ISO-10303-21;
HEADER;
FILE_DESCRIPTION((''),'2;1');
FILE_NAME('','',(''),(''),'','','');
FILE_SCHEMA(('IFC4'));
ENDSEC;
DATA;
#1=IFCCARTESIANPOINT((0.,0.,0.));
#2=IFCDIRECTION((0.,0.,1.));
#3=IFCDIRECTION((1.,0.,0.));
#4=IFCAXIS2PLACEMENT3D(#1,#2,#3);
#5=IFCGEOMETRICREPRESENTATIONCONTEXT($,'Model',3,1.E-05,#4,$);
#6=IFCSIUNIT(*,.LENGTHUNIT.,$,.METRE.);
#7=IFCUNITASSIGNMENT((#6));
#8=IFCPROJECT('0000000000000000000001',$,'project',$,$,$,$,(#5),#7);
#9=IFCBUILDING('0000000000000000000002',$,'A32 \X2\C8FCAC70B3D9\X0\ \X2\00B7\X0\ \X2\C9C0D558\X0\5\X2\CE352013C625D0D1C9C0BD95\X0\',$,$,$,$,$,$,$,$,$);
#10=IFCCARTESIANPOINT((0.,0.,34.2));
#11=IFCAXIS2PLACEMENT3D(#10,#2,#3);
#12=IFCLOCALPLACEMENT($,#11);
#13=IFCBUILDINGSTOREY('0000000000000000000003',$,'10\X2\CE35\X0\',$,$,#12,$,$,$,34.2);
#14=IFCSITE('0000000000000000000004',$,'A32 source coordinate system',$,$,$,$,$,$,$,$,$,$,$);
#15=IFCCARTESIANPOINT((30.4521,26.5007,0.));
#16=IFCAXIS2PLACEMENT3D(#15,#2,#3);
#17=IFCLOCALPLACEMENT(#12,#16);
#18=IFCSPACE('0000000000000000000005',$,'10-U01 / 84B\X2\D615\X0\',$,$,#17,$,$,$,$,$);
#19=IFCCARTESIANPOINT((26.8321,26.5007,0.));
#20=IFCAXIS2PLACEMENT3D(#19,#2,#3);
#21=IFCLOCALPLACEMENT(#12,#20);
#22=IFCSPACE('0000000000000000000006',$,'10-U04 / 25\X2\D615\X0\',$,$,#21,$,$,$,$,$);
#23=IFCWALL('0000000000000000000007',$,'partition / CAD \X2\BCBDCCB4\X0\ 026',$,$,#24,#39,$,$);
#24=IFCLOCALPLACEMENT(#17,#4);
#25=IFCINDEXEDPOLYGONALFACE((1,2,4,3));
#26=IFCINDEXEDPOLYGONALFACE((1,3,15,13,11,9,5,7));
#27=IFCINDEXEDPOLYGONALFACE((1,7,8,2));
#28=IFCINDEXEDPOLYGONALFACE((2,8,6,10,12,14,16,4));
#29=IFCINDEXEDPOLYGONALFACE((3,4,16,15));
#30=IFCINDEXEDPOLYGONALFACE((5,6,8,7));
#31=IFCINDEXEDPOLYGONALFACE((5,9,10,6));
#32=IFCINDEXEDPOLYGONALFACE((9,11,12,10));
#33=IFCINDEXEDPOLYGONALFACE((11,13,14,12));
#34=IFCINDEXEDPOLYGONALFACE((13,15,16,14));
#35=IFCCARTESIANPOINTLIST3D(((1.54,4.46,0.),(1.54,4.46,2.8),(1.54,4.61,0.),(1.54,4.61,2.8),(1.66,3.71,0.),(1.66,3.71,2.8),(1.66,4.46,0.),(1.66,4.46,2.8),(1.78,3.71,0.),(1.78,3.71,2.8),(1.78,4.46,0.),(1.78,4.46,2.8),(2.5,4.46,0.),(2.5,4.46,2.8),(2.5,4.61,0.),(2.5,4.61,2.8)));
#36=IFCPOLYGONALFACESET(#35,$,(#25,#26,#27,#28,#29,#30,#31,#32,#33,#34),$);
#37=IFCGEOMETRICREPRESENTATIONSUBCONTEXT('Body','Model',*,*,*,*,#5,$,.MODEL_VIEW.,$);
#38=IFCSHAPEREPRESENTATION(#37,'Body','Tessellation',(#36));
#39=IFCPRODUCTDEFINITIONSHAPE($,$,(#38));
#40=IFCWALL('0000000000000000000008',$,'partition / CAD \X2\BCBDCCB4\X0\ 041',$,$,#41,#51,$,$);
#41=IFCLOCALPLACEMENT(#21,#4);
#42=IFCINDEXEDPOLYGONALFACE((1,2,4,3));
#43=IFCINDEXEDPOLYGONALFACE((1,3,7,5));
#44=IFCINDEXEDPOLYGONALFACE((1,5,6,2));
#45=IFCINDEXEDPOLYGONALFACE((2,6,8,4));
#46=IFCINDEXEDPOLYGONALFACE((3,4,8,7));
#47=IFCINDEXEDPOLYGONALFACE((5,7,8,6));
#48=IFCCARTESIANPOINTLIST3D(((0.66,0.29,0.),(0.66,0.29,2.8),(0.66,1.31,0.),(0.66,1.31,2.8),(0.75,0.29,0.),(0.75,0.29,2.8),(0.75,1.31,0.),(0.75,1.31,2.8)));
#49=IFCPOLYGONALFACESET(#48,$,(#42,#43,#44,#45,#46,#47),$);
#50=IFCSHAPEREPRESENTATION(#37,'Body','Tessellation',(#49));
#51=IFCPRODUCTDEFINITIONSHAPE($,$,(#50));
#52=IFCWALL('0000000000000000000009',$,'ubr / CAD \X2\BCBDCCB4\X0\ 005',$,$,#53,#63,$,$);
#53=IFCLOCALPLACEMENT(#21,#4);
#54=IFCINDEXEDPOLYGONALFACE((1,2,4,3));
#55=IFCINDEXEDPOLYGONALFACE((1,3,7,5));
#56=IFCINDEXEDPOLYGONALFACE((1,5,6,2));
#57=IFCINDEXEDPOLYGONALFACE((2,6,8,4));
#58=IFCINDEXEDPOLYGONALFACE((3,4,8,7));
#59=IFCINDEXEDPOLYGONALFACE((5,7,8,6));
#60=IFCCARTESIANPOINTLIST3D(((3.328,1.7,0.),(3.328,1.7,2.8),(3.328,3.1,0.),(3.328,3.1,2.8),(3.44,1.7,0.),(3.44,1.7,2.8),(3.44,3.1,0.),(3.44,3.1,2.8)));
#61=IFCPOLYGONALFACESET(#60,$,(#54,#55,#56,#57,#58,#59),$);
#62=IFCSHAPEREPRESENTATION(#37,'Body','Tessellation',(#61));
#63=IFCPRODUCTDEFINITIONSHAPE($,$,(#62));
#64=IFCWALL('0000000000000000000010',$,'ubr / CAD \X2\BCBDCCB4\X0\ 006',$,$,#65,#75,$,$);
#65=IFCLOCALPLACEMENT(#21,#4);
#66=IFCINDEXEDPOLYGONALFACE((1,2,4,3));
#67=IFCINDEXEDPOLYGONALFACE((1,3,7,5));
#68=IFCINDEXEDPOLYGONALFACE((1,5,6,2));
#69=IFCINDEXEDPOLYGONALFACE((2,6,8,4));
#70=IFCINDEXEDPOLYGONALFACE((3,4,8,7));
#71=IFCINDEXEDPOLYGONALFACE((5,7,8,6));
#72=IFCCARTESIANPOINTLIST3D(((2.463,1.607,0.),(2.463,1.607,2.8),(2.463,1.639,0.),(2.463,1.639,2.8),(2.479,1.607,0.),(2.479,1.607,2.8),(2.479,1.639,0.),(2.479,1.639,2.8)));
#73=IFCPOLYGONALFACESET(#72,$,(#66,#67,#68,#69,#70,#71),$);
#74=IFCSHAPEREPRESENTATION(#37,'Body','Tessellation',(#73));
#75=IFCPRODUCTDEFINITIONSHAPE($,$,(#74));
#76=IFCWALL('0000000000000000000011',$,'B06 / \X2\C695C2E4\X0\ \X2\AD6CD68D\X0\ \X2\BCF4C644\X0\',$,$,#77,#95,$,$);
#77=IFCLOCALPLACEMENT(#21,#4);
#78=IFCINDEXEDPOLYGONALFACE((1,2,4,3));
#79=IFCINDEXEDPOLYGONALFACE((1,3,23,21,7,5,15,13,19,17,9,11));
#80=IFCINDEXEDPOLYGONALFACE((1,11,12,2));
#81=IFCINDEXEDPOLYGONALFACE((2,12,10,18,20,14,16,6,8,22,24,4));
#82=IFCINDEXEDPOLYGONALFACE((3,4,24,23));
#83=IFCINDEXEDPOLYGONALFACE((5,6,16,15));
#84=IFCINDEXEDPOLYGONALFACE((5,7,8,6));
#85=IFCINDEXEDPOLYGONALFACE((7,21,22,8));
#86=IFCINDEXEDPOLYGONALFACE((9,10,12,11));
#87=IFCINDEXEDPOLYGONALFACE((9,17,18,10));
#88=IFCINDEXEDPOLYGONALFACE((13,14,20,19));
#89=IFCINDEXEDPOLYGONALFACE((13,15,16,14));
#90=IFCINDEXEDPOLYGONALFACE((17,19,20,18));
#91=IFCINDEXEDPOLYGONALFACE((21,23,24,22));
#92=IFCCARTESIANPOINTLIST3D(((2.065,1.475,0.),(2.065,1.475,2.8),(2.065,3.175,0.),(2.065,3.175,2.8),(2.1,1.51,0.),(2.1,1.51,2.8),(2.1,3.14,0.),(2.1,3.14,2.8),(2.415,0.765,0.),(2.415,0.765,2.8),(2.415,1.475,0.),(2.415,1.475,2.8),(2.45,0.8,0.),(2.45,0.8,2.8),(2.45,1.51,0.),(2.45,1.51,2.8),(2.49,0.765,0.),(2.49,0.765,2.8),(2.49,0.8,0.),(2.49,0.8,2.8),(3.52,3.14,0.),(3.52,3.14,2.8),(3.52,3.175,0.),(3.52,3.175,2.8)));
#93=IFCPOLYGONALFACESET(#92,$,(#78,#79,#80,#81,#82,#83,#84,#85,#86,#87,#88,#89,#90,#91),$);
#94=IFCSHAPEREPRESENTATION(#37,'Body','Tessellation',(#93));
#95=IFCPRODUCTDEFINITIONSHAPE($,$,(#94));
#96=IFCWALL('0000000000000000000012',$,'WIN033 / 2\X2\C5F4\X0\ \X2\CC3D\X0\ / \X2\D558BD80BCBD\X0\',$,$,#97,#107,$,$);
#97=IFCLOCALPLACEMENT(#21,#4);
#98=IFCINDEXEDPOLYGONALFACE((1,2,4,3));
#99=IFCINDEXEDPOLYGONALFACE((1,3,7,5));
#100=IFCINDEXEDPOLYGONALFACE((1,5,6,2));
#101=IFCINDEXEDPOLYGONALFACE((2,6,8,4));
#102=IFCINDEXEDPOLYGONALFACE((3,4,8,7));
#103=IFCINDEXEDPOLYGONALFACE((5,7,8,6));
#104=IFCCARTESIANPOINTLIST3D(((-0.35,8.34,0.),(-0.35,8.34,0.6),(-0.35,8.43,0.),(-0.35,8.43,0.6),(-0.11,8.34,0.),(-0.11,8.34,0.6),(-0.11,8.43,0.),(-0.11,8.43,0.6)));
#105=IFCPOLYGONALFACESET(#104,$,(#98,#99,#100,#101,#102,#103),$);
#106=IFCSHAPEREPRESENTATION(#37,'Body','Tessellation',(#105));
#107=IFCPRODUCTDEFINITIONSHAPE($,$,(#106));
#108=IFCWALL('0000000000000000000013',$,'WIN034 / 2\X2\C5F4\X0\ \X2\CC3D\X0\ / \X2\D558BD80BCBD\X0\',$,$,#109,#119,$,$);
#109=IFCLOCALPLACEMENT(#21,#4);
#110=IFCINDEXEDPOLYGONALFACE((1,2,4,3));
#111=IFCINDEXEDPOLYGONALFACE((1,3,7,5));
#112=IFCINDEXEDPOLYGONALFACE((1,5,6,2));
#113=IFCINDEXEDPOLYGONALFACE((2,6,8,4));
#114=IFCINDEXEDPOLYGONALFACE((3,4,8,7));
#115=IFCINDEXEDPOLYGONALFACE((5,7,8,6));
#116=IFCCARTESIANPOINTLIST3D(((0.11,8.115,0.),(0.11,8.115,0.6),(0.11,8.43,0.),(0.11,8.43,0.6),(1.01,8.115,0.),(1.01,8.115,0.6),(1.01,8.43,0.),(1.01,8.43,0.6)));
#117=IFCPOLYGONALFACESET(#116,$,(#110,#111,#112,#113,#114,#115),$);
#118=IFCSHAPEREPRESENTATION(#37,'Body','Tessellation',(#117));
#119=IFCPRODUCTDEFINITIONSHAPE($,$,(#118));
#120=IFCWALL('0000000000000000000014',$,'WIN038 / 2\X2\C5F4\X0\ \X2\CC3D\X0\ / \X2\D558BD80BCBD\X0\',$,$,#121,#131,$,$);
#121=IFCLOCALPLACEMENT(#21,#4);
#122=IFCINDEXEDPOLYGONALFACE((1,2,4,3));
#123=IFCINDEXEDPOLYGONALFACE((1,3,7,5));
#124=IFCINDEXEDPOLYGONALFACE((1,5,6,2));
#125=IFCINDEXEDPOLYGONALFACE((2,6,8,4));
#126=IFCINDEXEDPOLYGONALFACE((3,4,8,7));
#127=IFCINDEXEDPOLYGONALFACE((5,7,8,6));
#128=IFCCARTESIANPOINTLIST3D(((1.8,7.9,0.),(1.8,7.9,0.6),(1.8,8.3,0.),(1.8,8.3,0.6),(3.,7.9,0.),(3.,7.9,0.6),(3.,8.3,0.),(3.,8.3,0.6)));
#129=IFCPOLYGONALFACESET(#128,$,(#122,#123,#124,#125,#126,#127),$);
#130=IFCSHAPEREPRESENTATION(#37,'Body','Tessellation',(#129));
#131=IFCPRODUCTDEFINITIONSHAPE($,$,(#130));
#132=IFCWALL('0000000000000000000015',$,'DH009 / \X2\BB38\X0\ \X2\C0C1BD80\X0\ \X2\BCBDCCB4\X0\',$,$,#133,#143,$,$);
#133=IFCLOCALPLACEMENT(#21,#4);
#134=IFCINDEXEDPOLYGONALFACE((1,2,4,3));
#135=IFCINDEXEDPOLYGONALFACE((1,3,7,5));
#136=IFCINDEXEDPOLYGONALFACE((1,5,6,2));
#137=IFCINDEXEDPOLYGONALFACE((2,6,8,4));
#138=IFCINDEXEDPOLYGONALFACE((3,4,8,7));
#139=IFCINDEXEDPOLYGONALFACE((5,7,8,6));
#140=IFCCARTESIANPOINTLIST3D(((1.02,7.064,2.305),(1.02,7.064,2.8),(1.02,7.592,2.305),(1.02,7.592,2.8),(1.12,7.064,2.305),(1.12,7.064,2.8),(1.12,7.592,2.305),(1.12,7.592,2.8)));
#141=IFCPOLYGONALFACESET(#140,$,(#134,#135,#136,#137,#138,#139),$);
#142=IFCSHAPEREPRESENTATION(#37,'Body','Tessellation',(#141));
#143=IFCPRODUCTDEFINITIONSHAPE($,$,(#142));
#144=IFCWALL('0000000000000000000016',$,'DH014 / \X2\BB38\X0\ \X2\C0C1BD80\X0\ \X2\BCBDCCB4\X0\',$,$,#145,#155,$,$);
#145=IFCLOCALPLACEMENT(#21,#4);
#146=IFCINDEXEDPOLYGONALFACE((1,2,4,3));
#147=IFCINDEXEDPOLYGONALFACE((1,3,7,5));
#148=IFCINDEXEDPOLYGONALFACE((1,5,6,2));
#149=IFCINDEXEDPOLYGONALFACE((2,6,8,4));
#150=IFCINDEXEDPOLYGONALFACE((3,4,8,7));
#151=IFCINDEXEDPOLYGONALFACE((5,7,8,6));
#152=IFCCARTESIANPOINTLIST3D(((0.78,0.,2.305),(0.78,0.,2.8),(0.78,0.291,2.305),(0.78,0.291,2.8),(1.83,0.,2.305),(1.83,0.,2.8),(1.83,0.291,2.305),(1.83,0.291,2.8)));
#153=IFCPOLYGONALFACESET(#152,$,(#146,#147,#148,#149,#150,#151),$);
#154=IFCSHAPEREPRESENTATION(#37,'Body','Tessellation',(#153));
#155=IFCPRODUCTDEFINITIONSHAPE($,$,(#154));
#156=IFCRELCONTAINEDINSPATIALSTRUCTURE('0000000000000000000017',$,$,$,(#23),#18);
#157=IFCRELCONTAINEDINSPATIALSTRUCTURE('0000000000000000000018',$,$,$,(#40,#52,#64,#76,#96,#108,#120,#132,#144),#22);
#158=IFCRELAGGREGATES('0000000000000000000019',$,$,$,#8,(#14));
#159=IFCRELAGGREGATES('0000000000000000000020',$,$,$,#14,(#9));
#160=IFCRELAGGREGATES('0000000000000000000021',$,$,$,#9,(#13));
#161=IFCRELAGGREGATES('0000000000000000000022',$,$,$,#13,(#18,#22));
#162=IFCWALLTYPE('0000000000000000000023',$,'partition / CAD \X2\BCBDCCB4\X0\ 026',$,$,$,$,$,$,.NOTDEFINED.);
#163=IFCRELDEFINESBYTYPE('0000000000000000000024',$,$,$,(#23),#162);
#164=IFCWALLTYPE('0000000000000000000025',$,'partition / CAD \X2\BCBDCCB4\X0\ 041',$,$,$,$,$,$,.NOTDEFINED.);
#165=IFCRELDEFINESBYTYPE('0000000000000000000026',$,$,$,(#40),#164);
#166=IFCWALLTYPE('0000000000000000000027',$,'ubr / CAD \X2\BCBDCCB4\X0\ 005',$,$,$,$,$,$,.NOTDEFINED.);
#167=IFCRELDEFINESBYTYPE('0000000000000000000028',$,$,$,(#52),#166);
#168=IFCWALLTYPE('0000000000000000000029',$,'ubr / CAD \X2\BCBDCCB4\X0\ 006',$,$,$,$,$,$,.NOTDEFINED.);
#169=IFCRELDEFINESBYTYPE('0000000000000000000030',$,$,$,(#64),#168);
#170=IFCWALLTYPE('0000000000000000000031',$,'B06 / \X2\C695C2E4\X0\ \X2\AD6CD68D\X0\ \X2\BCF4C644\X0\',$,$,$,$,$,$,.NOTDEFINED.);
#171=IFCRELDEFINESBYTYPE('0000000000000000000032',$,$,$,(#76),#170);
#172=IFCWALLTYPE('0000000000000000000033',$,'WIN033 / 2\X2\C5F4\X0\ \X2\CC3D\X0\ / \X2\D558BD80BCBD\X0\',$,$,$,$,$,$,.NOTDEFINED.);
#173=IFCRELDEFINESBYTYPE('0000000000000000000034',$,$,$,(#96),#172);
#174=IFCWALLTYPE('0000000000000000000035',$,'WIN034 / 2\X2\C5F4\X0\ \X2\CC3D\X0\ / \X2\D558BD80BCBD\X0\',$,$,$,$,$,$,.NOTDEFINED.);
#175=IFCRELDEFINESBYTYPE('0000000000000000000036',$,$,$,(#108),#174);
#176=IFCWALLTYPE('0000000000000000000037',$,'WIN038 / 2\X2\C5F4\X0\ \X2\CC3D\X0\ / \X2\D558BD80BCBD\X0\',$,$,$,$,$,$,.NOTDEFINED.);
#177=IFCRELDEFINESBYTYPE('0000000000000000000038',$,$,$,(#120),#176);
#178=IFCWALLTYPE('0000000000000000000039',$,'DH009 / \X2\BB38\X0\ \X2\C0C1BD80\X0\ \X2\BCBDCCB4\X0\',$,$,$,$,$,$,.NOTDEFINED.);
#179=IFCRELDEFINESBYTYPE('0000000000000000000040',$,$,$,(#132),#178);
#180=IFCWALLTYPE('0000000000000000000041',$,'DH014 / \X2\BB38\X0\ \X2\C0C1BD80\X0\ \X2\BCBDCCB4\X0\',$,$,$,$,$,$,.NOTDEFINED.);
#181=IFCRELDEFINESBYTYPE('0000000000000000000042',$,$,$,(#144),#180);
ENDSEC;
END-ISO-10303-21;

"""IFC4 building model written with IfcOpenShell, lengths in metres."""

from ifc_helpers import new_model, si_unit, frame, origin, origin_with_axes, place, context, subcontext, project, spatial, polyline, outline, extrude, source, transform, mapped, type_object, type_shapes, element, save


model = new_model("IFC4")

# Units and contexts
model_context = context("Model", 3, precision=1e-05, world=origin_with_axes())
body_context = subcontext(model_context, "Body", "Model", "MODEL_VIEW")
ifc_project = project(units=[si_unit("LENGTHUNIT", "METRE")], contexts=[model_context])

# Site, building, storey, space
site = spatial("IfcSite", under=ifc_project, Name="A32 source coordinate system")
building = spatial("IfcBuilding", under=site, Name="A32 주거동 · 지하5층–옥탑지붕")
storey_placement = place(None, frame((0.0, 0.0, 34.2), z_axis=(0.0, 0.0, 1.0), x_axis=(1.0, 0.0, 0.0)))
storey = spatial("IfcBuildingStorey", under=building, at=storey_placement, Name="10층", Elevation=34.2)
space_1_placement = place(storey_placement, frame((30.4521, 26.5007, 0.0), z_axis=(0.0, 0.0, 1.0), x_axis=(1.0, 0.0, 0.0)))
space_1 = spatial("IfcSpace", under=storey, at=space_1_placement, Name="10-U01 / 84B형")

# Wall
wall_type_1 = type_object("IfcWallType", Name="partition / CAD 벽체 026", PredefinedType="NOTDEFINED")
shared_shape_1 = source(origin(), body_context, "Body", "SweptSolid", [
    extrude(outline(polyline([(1.54, 4.46), (1.54, 4.61), (2.5, 4.61), (2.5, 4.46), (1.78, 4.46), (1.78, 3.71), (1.66, 3.71), (1.66, 4.46), (1.54, 4.46)])), origin(), (0.0, 0.0, 1.0), 2.8),
])
type_shapes(wall_type_1, [shared_shape_1])
wall_1_placement = place(space_1_placement, origin_with_axes())
element("IfcWall", 1, at=wall_1_placement, inside=space_1, type_object=wall_type_1, Name="partition / CAD 벽체 026", context=body_context, shape_type="MappedRepresentation", body=[
    mapped(shared_shape_1, transform((0.0, 0.0, 0.0), scale=1.0)),
])

# Shared definitions
space_2_placement = place(storey_placement, frame((26.8321, 26.5007, 0.0), z_axis=(0.0, 0.0, 1.0), x_axis=(1.0, 0.0, 0.0)))
space_2 = spatial("IfcSpace", under=storey, at=space_2_placement, Name="10-U04 / 25형")

# Walls
wall_type_2 = type_object("IfcWallType", Name="partition / CAD 벽체 041", PredefinedType="NOTDEFINED")
shared_shape_2 = source(origin(), body_context, "Body", "SweptSolid", [
    extrude(outline(polyline([(0.75, 1.31), (0.75, 0.29), (0.66, 0.29), (0.66, 1.31), (0.75, 1.31)])), origin(), (0.0, 0.0, 1.0), 2.8),
])
type_shapes(wall_type_2, [shared_shape_2])
wall_2_placement = place(space_2_placement, origin_with_axes())
element("IfcWall", 2, at=wall_2_placement, inside=space_2, type_object=wall_type_2, Name="partition / CAD 벽체 041", context=body_context, shape_type="MappedRepresentation", body=[
    mapped(shared_shape_2, transform((0.0, 0.0, 0.0), scale=1.0)),
])
wall_type_3 = type_object("IfcWallType", Name="ubr / CAD 벽체 005", PredefinedType="NOTDEFINED")
shared_shape_3 = source(origin(), body_context, "Body", "SweptSolid", [
    extrude(outline(polyline([(3.44, 3.1), (3.44, 1.7), (3.328, 1.7), (3.328, 3.1), (3.44, 3.1)])), origin(), (0.0, 0.0, 1.0), 2.8),
])
type_shapes(wall_type_3, [shared_shape_3])
wall_3_placement = place(space_2_placement, origin_with_axes())
element("IfcWall", 3, at=wall_3_placement, inside=space_2, type_object=wall_type_3, Name="ubr / CAD 벽체 005", context=body_context, shape_type="MappedRepresentation", body=[
    mapped(shared_shape_3, transform((0.0, 0.0, 0.0), scale=1.0)),
])
wall_type_4 = type_object("IfcWallType", Name="ubr / CAD 벽체 006", PredefinedType="NOTDEFINED")
shared_shape_4 = source(origin(), body_context, "Body", "SweptSolid", [
    extrude(outline(polyline([(2.463, 1.639), (2.479, 1.639), (2.479, 1.607), (2.463, 1.607), (2.463, 1.639)])), origin(), (0.0, 0.0, 1.0), 2.8),
])
type_shapes(wall_type_4, [shared_shape_4])
wall_4_placement = place(space_2_placement, origin_with_axes())
element("IfcWall", 4, at=wall_4_placement, inside=space_2, type_object=wall_type_4, Name="ubr / CAD 벽체 006", context=body_context, shape_type="MappedRepresentation", body=[
    mapped(shared_shape_4, transform((0.0, 0.0, 0.0), scale=1.0)),
])
wall_type_5 = type_object("IfcWallType", Name="B06 / 욕실 구획 보완", PredefinedType="NOTDEFINED")
shared_shape_5 = source(origin(), body_context, "Body", "SweptSolid", [
    extrude(outline(polyline([(3.52, 3.14), (2.1, 3.14), (2.1, 1.51), (2.45, 1.51), (2.45, 0.8), (2.49, 0.8), (2.49, 0.765), (2.415, 0.765), (2.415, 1.475), (2.065, 1.475), (2.065, 3.175), (3.52, 3.175), (3.52, 3.14)])), origin(), (0.0, 0.0, 1.0), 2.8),
])
type_shapes(wall_type_5, [shared_shape_5])
wall_5_placement = place(space_2_placement, origin_with_axes())
element("IfcWall", 5, at=wall_5_placement, inside=space_2, type_object=wall_type_5, Name="B06 / 욕실 구획 보완", context=body_context, shape_type="MappedRepresentation", body=[
    mapped(shared_shape_5, transform((0.0, 0.0, 0.0), scale=1.0)),
])
wall_type_6 = type_object("IfcWallType", Name="WIN033 / 2열 창 / 하부벽", PredefinedType="NOTDEFINED")
shared_shape_6 = source(origin(), body_context, "Body", "SweptSolid", [
    extrude(outline(polyline([(-0.11, 8.43), (-0.11, 8.34), (-0.35, 8.34), (-0.35, 8.43), (-0.11, 8.43)])), origin(), (0.0, 0.0, 1.0), 0.6),
])
type_shapes(wall_type_6, [shared_shape_6])
wall_6_placement = place(space_2_placement, origin_with_axes())
element("IfcWall", 6, at=wall_6_placement, inside=space_2, type_object=wall_type_6, Name="WIN033 / 2열 창 / 하부벽", context=body_context, shape_type="MappedRepresentation", body=[
    mapped(shared_shape_6, transform((0.0, 0.0, 0.0), scale=1.0)),
])
wall_type_7 = type_object("IfcWallType", Name="WIN034 / 2열 창 / 하부벽", PredefinedType="NOTDEFINED")
shared_shape_7 = source(origin(), body_context, "Body", "SweptSolid", [
    extrude(outline(polyline([(0.11, 8.115), (0.11, 8.43), (1.01, 8.43), (1.01, 8.115), (0.11, 8.115)])), origin(), (0.0, 0.0, 1.0), 0.6),
])
type_shapes(wall_type_7, [shared_shape_7])
wall_7_placement = place(space_2_placement, origin_with_axes())
element("IfcWall", 7, at=wall_7_placement, inside=space_2, type_object=wall_type_7, Name="WIN034 / 2열 창 / 하부벽", context=body_context, shape_type="MappedRepresentation", body=[
    mapped(shared_shape_7, transform((0.0, 0.0, 0.0), scale=1.0)),
])
wall_type_8 = type_object("IfcWallType", Name="WIN038 / 2열 창 / 하부벽", PredefinedType="NOTDEFINED")
shared_shape_8 = source(origin(), body_context, "Body", "SweptSolid", [
    extrude(outline(polyline([(1.8, 7.9), (1.8, 8.3), (3.0, 8.3), (3.0, 7.9), (1.8, 7.9)])), origin(), (0.0, 0.0, 1.0), 0.6),
])
type_shapes(wall_type_8, [shared_shape_8])
wall_8_placement = place(space_2_placement, origin_with_axes())
element("IfcWall", 8, at=wall_8_placement, inside=space_2, type_object=wall_type_8, Name="WIN038 / 2열 창 / 하부벽", context=body_context, shape_type="MappedRepresentation", body=[
    mapped(shared_shape_8, transform((0.0, 0.0, 0.0), scale=1.0)),
])
wall_type_9 = type_object("IfcWallType", Name="DH009 / 문 상부 벽체", PredefinedType="NOTDEFINED")
shared_shape_9 = source(origin(), body_context, "Body", "SweptSolid", [
    extrude(outline(polyline([(1.02, 7.064), (1.02, 7.592), (1.12, 7.592), (1.12, 7.064), (1.02, 7.064)])), frame((0.0, 0.0, 2.305)), (0.0, 0.0, 1.0), 0.495),
])
type_shapes(wall_type_9, [shared_shape_9])
wall_9_placement = place(space_2_placement, origin_with_axes())
element("IfcWall", 9, at=wall_9_placement, inside=space_2, type_object=wall_type_9, Name="DH009 / 문 상부 벽체", context=body_context, shape_type="MappedRepresentation", body=[
    mapped(shared_shape_9, transform((0.0, 0.0, 0.0), scale=1.0)),
])
wall_type_10 = type_object("IfcWallType", Name="DH014 / 문 상부 벽체", PredefinedType="NOTDEFINED")
shared_shape_10 = source(origin(), body_context, "Body", "SweptSolid", [
    extrude(outline(polyline([(0.78, 0.291), (1.83, 0.291), (1.83, 0.0), (0.78, 0.0), (0.78, 0.291)])), frame((0.0, 0.0, 2.305)), (0.0, 0.0, 1.0), 0.495),
])
type_shapes(wall_type_10, [shared_shape_10])
wall_10_placement = place(space_2_placement, origin_with_axes())
element("IfcWall", 10, at=wall_10_placement, inside=space_2, type_object=wall_type_10, Name="DH014 / 문 상부 벽체", context=body_context, shape_type="MappedRepresentation", body=[
    mapped(shared_shape_10, transform((0.0, 0.0, 0.0), scale=1.0)),
])

save(model, "model.ifc")
